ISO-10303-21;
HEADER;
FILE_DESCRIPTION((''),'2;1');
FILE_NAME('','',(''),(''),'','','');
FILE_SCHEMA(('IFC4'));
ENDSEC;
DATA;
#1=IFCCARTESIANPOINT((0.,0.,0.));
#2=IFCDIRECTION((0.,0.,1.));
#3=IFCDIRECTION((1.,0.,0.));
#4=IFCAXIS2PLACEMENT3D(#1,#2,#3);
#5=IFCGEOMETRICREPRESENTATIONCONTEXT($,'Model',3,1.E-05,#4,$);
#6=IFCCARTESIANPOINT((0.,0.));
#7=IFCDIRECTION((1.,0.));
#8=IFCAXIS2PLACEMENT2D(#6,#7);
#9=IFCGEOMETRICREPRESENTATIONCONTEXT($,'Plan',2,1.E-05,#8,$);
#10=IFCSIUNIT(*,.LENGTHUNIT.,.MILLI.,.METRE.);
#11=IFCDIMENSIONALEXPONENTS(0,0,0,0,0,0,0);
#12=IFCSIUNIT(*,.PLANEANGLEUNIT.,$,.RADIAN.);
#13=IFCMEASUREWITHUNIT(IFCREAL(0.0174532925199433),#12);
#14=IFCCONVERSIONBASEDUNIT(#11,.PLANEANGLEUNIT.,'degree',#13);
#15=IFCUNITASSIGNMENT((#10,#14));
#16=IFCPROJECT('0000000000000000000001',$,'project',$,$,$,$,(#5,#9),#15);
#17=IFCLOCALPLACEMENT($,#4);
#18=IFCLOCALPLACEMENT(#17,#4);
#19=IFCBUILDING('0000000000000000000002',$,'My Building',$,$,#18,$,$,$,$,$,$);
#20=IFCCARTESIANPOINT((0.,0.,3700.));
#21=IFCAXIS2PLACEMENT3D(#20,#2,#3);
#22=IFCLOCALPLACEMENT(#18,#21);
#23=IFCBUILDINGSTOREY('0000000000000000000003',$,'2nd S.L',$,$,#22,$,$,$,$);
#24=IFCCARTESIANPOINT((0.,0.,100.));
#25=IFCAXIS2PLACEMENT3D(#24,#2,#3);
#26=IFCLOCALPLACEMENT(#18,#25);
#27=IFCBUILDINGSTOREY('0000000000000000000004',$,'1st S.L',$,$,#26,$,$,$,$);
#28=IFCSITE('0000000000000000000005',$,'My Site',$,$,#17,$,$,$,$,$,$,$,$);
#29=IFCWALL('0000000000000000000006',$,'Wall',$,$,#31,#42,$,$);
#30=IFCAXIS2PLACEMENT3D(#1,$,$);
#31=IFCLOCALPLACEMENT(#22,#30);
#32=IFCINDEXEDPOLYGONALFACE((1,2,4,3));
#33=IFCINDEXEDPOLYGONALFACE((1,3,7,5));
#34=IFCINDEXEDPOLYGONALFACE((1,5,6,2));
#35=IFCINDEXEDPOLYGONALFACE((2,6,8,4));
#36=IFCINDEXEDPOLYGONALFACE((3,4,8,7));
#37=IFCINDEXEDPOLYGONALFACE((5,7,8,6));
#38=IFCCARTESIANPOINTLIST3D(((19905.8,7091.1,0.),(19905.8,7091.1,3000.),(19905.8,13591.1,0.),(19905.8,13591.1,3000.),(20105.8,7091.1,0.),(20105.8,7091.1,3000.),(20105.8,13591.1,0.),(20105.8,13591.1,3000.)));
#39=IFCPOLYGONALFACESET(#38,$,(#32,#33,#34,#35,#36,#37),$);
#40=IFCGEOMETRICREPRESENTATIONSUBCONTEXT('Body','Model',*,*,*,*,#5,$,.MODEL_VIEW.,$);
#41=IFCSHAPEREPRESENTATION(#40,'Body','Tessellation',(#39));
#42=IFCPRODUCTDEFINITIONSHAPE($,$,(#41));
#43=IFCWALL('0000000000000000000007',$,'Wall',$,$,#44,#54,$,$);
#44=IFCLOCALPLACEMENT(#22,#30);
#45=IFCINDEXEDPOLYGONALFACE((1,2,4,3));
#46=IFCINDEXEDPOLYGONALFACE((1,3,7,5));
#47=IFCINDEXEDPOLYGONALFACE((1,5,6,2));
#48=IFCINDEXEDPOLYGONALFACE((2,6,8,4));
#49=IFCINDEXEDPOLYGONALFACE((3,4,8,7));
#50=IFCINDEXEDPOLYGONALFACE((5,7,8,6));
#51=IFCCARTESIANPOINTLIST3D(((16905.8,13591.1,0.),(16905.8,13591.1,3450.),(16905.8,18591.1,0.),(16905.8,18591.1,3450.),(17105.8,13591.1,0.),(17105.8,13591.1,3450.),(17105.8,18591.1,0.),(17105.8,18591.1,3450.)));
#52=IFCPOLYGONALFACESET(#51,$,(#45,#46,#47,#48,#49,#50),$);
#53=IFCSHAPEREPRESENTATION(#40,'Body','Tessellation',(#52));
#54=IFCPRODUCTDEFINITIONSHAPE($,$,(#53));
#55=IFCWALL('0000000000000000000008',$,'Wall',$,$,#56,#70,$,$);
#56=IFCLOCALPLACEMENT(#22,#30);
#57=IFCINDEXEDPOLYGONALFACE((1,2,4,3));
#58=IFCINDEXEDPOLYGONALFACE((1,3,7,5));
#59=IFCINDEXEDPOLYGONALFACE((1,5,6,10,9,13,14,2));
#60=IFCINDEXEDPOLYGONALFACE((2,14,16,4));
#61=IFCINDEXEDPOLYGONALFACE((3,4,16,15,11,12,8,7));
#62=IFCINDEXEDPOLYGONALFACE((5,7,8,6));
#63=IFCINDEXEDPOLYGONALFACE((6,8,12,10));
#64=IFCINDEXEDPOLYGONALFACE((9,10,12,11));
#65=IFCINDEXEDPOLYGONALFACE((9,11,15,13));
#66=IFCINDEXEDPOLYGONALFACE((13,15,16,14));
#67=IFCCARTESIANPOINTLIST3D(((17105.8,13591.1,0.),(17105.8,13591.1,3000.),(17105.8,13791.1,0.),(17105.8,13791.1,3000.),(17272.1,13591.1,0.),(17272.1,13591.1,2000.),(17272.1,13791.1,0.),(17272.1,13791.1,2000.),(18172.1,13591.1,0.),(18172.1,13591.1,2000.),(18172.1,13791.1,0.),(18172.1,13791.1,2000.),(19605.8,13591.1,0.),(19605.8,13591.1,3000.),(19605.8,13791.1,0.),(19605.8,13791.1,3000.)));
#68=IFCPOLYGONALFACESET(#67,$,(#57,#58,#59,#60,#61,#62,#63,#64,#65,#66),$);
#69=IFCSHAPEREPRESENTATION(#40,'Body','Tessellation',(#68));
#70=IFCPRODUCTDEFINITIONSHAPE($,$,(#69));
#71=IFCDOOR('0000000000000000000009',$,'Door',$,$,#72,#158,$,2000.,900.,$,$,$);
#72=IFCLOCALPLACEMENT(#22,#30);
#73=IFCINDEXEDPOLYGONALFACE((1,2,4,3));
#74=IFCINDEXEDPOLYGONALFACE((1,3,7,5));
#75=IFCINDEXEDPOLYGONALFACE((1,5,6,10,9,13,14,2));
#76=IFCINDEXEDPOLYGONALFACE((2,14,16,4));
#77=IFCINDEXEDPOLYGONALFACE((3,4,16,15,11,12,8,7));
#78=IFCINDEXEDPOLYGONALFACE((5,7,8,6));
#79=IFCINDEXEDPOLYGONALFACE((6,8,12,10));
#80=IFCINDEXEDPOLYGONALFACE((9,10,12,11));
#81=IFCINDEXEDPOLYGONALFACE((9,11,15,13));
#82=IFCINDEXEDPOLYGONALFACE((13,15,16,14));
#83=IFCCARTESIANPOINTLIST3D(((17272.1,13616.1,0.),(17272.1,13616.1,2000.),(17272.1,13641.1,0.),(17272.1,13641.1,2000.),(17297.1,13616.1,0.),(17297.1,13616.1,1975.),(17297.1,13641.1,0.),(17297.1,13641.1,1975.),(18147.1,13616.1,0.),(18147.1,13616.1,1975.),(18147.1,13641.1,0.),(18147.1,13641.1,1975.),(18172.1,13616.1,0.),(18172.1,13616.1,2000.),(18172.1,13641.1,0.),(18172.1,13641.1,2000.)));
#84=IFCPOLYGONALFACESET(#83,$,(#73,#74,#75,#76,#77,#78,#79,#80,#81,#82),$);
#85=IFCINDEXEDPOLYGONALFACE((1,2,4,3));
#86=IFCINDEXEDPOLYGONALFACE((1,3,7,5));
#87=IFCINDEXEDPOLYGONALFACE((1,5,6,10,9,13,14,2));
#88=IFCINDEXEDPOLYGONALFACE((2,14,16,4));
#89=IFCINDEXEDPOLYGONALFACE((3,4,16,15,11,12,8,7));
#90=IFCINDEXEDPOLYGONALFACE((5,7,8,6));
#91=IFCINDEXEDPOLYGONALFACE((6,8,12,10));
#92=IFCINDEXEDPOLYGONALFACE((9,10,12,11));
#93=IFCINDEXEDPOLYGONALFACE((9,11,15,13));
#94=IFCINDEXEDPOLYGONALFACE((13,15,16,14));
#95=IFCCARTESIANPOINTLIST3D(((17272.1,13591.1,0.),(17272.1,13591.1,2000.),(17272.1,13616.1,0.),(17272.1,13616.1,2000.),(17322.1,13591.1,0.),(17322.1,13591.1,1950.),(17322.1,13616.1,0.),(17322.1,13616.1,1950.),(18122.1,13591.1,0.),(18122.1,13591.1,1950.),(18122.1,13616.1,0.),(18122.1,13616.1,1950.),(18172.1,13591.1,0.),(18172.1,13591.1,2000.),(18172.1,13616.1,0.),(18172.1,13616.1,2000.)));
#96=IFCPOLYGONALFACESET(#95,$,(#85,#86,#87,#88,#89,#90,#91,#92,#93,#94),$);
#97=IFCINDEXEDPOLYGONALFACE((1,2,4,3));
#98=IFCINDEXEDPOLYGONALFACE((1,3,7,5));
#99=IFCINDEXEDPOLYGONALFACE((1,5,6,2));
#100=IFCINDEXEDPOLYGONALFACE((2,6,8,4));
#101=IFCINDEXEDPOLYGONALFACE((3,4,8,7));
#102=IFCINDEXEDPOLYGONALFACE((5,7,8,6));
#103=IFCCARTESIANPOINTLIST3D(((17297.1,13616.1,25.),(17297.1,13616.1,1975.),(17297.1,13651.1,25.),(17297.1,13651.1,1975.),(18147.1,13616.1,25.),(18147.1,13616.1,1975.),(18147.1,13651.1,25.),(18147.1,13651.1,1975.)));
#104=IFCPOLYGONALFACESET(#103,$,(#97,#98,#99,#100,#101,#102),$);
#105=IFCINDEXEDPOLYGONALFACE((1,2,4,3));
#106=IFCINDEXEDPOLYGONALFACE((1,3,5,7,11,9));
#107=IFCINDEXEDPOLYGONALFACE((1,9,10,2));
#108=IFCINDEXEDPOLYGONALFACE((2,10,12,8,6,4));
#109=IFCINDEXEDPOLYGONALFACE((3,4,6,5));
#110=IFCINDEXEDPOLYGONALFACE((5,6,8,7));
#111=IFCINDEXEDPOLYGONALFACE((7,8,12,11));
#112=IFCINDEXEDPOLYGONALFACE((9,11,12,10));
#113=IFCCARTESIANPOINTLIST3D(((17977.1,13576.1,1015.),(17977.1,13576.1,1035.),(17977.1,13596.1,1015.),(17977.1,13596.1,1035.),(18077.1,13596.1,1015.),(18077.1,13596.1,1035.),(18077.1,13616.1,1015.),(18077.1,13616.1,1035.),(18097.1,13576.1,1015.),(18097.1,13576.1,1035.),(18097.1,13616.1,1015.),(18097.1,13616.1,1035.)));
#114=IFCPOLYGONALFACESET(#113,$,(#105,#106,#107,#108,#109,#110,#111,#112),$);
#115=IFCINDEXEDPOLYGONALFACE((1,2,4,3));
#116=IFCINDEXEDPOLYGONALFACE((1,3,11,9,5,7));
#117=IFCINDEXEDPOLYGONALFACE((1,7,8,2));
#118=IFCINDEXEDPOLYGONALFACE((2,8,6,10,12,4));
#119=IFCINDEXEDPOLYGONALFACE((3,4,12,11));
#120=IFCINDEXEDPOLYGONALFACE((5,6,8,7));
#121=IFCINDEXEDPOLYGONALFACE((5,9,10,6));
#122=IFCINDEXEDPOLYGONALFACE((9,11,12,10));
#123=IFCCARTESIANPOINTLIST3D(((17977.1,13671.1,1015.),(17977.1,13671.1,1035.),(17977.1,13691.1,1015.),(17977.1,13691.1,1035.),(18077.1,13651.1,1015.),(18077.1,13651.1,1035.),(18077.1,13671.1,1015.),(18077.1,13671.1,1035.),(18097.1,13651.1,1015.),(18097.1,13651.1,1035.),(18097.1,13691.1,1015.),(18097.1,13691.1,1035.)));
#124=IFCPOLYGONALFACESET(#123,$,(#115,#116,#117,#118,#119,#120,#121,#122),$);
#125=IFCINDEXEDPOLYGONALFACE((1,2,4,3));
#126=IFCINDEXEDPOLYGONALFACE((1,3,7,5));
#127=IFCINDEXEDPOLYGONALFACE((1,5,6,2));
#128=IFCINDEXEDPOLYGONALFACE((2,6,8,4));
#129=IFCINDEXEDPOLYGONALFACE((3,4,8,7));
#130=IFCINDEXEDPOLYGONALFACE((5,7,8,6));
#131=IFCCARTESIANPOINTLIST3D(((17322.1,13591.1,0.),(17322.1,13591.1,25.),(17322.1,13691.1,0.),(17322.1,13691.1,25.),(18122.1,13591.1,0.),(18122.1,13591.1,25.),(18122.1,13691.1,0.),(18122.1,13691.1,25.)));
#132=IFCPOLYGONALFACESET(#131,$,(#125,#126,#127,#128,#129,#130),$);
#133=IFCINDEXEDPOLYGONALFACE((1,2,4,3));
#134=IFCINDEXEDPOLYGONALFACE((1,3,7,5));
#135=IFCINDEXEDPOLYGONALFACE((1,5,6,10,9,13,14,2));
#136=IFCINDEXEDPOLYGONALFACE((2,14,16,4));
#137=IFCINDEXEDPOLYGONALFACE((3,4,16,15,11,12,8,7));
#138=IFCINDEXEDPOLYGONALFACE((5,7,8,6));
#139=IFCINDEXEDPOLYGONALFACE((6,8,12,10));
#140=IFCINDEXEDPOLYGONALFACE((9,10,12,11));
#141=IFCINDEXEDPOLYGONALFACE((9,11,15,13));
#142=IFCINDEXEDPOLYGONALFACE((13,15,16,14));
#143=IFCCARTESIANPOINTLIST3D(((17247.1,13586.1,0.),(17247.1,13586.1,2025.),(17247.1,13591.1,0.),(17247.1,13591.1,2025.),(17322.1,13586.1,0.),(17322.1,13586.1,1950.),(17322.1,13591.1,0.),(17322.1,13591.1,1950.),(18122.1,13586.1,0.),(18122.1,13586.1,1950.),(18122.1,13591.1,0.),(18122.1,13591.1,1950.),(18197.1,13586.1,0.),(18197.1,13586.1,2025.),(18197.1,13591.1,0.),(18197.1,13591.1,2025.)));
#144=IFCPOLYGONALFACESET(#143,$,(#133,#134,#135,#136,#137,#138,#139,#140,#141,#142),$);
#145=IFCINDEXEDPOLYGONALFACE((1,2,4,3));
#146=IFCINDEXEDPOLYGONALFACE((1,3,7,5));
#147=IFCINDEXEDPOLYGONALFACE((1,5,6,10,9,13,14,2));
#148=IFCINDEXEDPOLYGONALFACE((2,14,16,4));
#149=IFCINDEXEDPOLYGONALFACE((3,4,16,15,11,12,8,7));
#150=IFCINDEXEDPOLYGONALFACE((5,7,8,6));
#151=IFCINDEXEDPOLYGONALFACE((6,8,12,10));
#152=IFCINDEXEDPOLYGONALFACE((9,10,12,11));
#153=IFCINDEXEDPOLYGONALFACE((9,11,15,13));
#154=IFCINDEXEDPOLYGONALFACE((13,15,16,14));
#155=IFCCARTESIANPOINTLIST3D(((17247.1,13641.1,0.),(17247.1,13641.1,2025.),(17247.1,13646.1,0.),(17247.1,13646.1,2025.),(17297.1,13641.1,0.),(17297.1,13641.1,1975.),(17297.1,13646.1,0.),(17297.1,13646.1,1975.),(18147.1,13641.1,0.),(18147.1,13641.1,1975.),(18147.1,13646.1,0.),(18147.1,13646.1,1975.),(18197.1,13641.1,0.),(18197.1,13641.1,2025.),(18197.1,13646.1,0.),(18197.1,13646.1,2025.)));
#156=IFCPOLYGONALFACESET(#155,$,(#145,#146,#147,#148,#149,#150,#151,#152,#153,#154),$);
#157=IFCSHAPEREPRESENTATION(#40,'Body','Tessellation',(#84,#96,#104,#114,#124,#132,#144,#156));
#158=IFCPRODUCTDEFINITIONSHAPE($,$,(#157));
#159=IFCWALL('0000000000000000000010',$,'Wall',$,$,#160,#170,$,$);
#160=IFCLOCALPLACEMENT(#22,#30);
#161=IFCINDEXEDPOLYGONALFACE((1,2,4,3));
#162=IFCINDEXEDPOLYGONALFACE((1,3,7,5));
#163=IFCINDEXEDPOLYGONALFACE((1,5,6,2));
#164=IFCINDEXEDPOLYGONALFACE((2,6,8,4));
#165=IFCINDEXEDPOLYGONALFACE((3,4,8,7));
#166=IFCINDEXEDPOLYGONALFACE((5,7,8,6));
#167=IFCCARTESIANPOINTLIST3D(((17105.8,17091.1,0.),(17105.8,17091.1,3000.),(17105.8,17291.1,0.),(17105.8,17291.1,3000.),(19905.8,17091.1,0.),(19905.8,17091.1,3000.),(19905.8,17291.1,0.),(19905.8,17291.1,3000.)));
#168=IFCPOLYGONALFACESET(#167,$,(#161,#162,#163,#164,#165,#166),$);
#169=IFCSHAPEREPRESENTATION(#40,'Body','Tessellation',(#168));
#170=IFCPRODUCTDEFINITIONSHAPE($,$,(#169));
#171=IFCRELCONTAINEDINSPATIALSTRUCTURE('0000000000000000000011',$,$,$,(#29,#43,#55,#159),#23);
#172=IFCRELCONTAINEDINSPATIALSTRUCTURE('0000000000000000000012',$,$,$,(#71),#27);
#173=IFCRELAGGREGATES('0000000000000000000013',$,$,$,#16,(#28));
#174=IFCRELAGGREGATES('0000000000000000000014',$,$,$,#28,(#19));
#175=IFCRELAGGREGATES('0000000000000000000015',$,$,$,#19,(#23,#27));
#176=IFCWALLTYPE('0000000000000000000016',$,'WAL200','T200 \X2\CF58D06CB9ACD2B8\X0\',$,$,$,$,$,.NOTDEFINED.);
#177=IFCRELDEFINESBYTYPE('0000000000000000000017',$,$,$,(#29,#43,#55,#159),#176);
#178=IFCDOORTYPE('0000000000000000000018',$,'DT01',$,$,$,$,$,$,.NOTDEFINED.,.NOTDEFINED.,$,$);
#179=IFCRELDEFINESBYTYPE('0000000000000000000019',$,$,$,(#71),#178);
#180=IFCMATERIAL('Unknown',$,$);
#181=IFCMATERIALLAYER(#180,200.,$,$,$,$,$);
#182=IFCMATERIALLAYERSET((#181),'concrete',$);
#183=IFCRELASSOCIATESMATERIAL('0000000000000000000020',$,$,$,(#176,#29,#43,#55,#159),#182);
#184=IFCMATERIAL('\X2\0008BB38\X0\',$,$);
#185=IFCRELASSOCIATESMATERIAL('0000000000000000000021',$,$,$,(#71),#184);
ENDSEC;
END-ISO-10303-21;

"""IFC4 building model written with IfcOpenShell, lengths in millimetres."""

from ifc_helpers import new_model, entity, si_unit, converted_unit, frame, origin_with_axes, origin_2d_with_axis, place, context, subcontext, project, spatial, line, indexed_curve, outline, extrude, clip, halfspace, shape, source, transform, mapped, material, layer, layer_set, layer_usage, type_object, type_shapes, element, fill, save


model = new_model("IFC4")

# Units and contexts
model_context = context("Model", 3, precision=1e-05, world=origin_with_axes())
plan_context = context("Plan", 2, precision=1e-05, world=origin_2d_with_axis())
body_context_1 = subcontext(model_context, "Body", "Model", "MODEL_VIEW")
body_context_2 = subcontext(plan_context, "Body", "Plan", "PLAN_VIEW")
ifc_project = project(units=[si_unit("LENGTHUNIT", "METRE", prefix="MILLI"), converted_unit("PLANEANGLEUNIT", "degree", entity("IfcReal", 0.0174532925199433), si_unit("PLANEANGLEUNIT", "RADIAN"), dimensions=[0, 0, 0, 0, 0, 0, 0])], contexts=[model_context, plan_context])

# Site, building, storey
site_placement = place(None, origin_with_axes())
site = spatial("IfcSite", under=ifc_project, at=site_placement, Name="My Site")
building_placement = place(site_placement, origin_with_axes())
building = spatial("IfcBuilding", under=site, at=building_placement, Name="My Building")
storey_1_placement = place(building_placement, frame((0.0, 0.0, 3700.0), z_axis=(0.0, 0.0, 1.0), x_axis=(1.0, 0.0, 0.0)))
storey_1 = spatial("IfcBuildingStorey", under=building, at=storey_1_placement, Name="2nd S.L")

# Shared definitions
ifc_material_1 = material(Name="Unknown")

# Walls
ifc_layer = layer(ifc_material_1, 200.0)
ifc_layer_set = layer_set([ifc_layer], Name="concrete")
wall_type = type_object("IfcWallType", Name="WAL200", Description="T200 콘크리트", PredefinedType="NOTDEFINED", material=ifc_layer_set)
ifc_layer_usage_1 = layer_usage(ifc_layer_set, "AXIS2", "POSITIVE", 0.0)
wall_1_placement = place(storey_1_placement, frame((20105.8, 7091.1, 0.0), z_axis=(0.0, 0.0, 1.0), x_axis=(0.0, 1.0, 0.0)))
element("IfcWall", 1, at=wall_1_placement, inside=storey_1, type_object=wall_type, material=ifc_layer_usage_1, Name="Wall", context=body_context_1, shape_type="SweptSolid", body=[
    extrude(outline(indexed_curve([(0.0, 0.0), (0.0, 200.0), (6500.0, 200.0), (6500.0, 0.0), (0.0, 0.0)], self_intersect=False)), origin_with_axes(), (0.0, 0.0, 1.0), 3000.0),
])
ifc_layer_usage_2 = layer_usage(ifc_layer_set, "AXIS2", "POSITIVE", 0.0)
wall_2_placement = place(storey_1_placement, frame((17105.8, 13591.1, 0.0), z_axis=(0.0, 0.0, 1.0), x_axis=(0.0, 1.0, 0.0)))
element("IfcWall", 2, at=wall_2_placement, inside=storey_1, type_object=wall_type, material=ifc_layer_usage_2, Name="Wall", context=body_context_1, shape_type="Clipping", body=[
    clip(extrude(outline(indexed_curve([(0.0, 0.0), (0.0, 200.0), (5000.0, 200.0), (5000.0, 0.0), (0.0, 0.0)], self_intersect=False)), origin_with_axes(), (0.0, 0.0, 1.0), 3450.0), halfspace(frame((0.0, 0.0, 3450.0), z_axis=(0.0, 0.0, 1.0), x_axis=(-1.0, 0.0, 0.0)), False)),
])

# Wall, opening
ifc_layer_usage_3 = layer_usage(ifc_layer_set, "AXIS2", "POSITIVE", 0.0)
wall_3_placement = place(storey_1_placement, frame((17105.8, 13591.1, 0.0), z_axis=(0.0, 0.0, 1.0), x_axis=(1.0, 0.0, 0.0)))
wall_3 = element("IfcWall", 3, at=wall_3_placement, inside=storey_1, type_object=wall_type, material=ifc_layer_usage_3, Name="Wall", context=body_context_1, shape_type="SweptSolid", body=[
    extrude(outline(indexed_curve([(0.0, 0.0), (0.0, 200.0), (2500.0, 200.0), (2500.0, 0.0), (0.0, 0.0)], self_intersect=False)), origin_with_axes(), (0.0, 0.0, 1.0), 3000.0),
])
shared_shape_1 = source(origin_with_axes(), body_context_1, "Body", "SolidModel", [
    extrude(outline(indexed_curve([(0.0, 0.0), (900.0, 0.0), (900.0, 2000.0), (0.0, 2000.0)], segments=[line(1, 2, 3, 4, 1)])), frame((0.0, -600.0, 0.0), z_axis=(0.0, -1.0, 0.0), x_axis=(1.0, 0.0, 0.0)), (0.0, 0.0, -1.0), 1200.0),
])
opening_placement = place(wall_3_placement, frame((166.3, 0.0, 0.0), z_axis=(0.0, 0.0, 1.0), x_axis=(1.0, 0.0, 0.0)))
opening = element("IfcOpeningElement", 4, at=opening_placement, cuts=wall_3, PredefinedType="OPENING", context=body_context_1, shape_type="MappedRepresentation", body=[
    mapped(shared_shape_1, transform((0.0, 0.0, 0.0), x_axis=(1.0, 0.0, 0.0), y_axis=(0.0, 1.0, 0.0), z_axis=(0.0, 0.0, 1.0), scale=1.0)),
])

# Shared definitions
storey_2_placement = place(building_placement, frame((0.0, 0.0, 100.0), z_axis=(0.0, 0.0, 1.0), x_axis=(1.0, 0.0, 0.0)))
storey_2 = spatial("IfcBuildingStorey", under=building, at=storey_2_placement, Name="1st S.L")

# Door
ifc_material_2 = material(Name="\b문")
door_type = type_object("IfcDoorType", Name="DT01", OperationType="NOTDEFINED", PredefinedType="NOTDEFINED")
shared_shape_2 = source(origin_with_axes(), body_context_1, "Body", "SolidModel", [
    extrude(outline(indexed_curve([(0.0, 0.0), (0.0, 2000.0), (900.0, 2000.0), (900.0, 0.0), (875.0, 0.0), (875.0, 1975.0), (25.0, 1975.0), (25.0, 0.0)], segments=[line(1, 2, 3, 4, 5, 6, 7, 8, 1)])), frame((0.0, 25.0, 0.0), z_axis=(0.0, -1.0, 0.0), x_axis=(1.0, 0.0, 0.0)), (0.0, 0.0, -1.0), 25.0),
    extrude(outline(indexed_curve([(0.0, 0.0), (0.0, 2000.0), (900.0, 2000.0), (900.0, 0.0), (850.0, 0.0), (850.0, 1950.0), (50.0, 1950.0), (50.0, 0.0)], segments=[line(1, 2, 3, 4, 5, 6, 7, 8, 1)])), frame((0.0, 0.0, 0.0), z_axis=(0.0, -1.0, 0.0), x_axis=(1.0, 0.0, 0.0)), (0.0, 0.0, -1.0), 25.0),
    extrude(outline(indexed_curve([(0.0, 0.0), (850.0, 0.0), (850.0, 35.0), (0.0, 35.0)], segments=[line(1, 2, 3, 4, 1)])), frame((25.0, 25.0, 25.0), z_axis=(0.0, 0.0, 1.0), x_axis=(1.0, 0.0, 0.0)), (0.0, 0.0, 1.0), 1950.0),
    extrude(outline(indexed_curve([(0.0, 0.0), (0.0, -40.0), (-120.0, -40.0), (-120.0, -20.0), (-20.0, -20.0), (-20.0, 0.0)], segments=[line(1, 2, 3, 4, 5, 6, 1)])), frame((825.0, 25.0, 1015.0), z_axis=(0.0, 0.0, 1.0), x_axis=(1.0, 0.0, 0.0)), (0.0, 0.0, 1.0), 20.0),
    extrude(outline(indexed_curve([(0.0, 0.0), (0.0, 40.0), (-120.0, 40.0), (-120.0, 20.0), (-20.0, 20.0), (-20.0, 0.0)], segments=[line(1, 2, 3, 4, 5, 6, 1)])), frame((825.0, 60.0, 1015.0), z_axis=(0.0, 0.0, 1.0), x_axis=(1.0, 0.0, 0.0)), (0.0, 0.0, 1.0), 20.0),
    extrude(outline(indexed_curve([(0.0, 0.0), (800.0, 0.0), (800.0, 100.0), (0.0, 100.0)], segments=[line(1, 2, 3, 4, 1)])), frame((50.0, 0.0, 0.0), z_axis=(0.0, 0.0, 1.0), x_axis=(1.0, 0.0, 0.0)), (0.0, 0.0, 1.0), 25.0),
    extrude(outline(indexed_curve([(0.0, 0.0), (0.0, 2025.0), (950.0, 2025.0), (950.0, 0.0), (875.0, 0.0), (875.0, 1950.0), (75.0, 1950.0), (75.0, 0.0)], segments=[line(1, 2, 3, 4, 5, 6, 7, 8, 1)])), frame((-25.0, -5.0, 0.0), z_axis=(0.0, -1.0, 0.0), x_axis=(1.0, 0.0, 0.0)), (0.0, 0.0, -1.0), 5.0),
    extrude(outline(indexed_curve([(0.0, 0.0), (0.0, 2025.0), (950.0, 2025.0), (950.0, 0.0), (900.0, 0.0), (900.0, 1975.0), (50.0, 1975.0), (50.0, 0.0)], segments=[line(1, 2, 3, 4, 5, 6, 7, 8, 1)])), frame((-25.0, 50.0, 0.0), z_axis=(0.0, -1.0, 0.0), x_axis=(1.0, 0.0, 0.0)), (0.0, 0.0, -1.0), 5.0),
])
shared_shape_3 = source(origin_with_axes(), body_context_2, "Body", "Curve2D", [
    entity("IfcIndexedPolyCurve", entity("IfcCartesianPointList2D", [[0.0, 0.0], [0.0, 50.0], [25.0, 50.0], [25.0, 25.0], [50.0, 25.0], [50.0, 0.0]]), [entity("IfcLineIndex", [1, 2, 3, 4, 5, 6, 1])]),
    entity("IfcIndexedPolyCurve", entity("IfcCartesianPointList2D", [[900.0, 0.0], [900.0, 50.0], [875.0, 50.0], [875.0, 25.0], [850.0, 25.0], [850.0, 0.0]]), [entity("IfcLineIndex", [1, 2, 3, 4, 5, 6, 1])]),
    entity("IfcTrimmedCurve", entity("IfcEllipse", entity("IfcAxis2Placement2D", entity("IfcCartesianPoint", [60.0, 50.0]), entity("IfcDirection", [1.0, 0.0])), 815.0, 850.0), [entity("IfcCartesianPoint", [875.0, 50.0])], [entity("IfcCartesianPoint", [60.0, 900.0])], True, "CARTESIAN"),
    entity("IfcIndexedPolyCurve", entity("IfcCartesianPointList2D", [[25.0, 50.0], [60.0, 50.0], [60.0, 900.0], [25.0, 900.0]]), [entity("IfcLineIndex", [1, 2, 3, 4, 1])]),
])
type_shapes(door_type, [shared_shape_2, shared_shape_3])
door_placement = place(opening_placement, origin_with_axes())
door = element("IfcDoor", 5, at=door_placement, inside=storey_2, type_object=door_type, material=ifc_material_2, Name="Door", OverallHeight=2000.0, OverallWidth=900.0, shapes=[
    shape(body_context_1, "Body", "MappedRepresentation", [mapped(shared_shape_2, transform((0.0, 0.0, 0.0), x_axis=(1.0, 0.0, 0.0), y_axis=(0.0, 1.0, 0.0), z_axis=(0.0, 0.0, 1.0), scale=1.0))]),
    shape(body_context_2, "Body", "MappedRepresentation", [mapped(shared_shape_3, transform((0.0, 0.0, 0.0), x_axis=(1.0, 0.0, 0.0), y_axis=(0.0, 1.0, 0.0), z_axis=(0.0, 0.0, 1.0), scale=1.0))]),
])
fill(opening, door)

# Wall
ifc_layer_usage_4 = layer_usage(ifc_layer_set, "AXIS2", "POSITIVE", 0.0)
wall_4_placement = place(storey_1_placement, frame((17105.8, 17091.1, 0.0), z_axis=(0.0, 0.0, 1.0), x_axis=(1.0, 0.0, 0.0)))
element("IfcWall", 6, at=wall_4_placement, inside=storey_1, type_object=wall_type, material=ifc_layer_usage_4, Name="Wall", context=body_context_1, shape_type="SweptSolid", body=[
    extrude(outline(indexed_curve([(0.0, 0.0), (0.0, 200.0), (2800.0, 200.0), (2800.0, 0.0), (0.0, 0.0)], self_intersect=False)), origin_with_axes(), (0.0, 0.0, 1.0), 3000.0),
])

save(model, "model.ifc")
